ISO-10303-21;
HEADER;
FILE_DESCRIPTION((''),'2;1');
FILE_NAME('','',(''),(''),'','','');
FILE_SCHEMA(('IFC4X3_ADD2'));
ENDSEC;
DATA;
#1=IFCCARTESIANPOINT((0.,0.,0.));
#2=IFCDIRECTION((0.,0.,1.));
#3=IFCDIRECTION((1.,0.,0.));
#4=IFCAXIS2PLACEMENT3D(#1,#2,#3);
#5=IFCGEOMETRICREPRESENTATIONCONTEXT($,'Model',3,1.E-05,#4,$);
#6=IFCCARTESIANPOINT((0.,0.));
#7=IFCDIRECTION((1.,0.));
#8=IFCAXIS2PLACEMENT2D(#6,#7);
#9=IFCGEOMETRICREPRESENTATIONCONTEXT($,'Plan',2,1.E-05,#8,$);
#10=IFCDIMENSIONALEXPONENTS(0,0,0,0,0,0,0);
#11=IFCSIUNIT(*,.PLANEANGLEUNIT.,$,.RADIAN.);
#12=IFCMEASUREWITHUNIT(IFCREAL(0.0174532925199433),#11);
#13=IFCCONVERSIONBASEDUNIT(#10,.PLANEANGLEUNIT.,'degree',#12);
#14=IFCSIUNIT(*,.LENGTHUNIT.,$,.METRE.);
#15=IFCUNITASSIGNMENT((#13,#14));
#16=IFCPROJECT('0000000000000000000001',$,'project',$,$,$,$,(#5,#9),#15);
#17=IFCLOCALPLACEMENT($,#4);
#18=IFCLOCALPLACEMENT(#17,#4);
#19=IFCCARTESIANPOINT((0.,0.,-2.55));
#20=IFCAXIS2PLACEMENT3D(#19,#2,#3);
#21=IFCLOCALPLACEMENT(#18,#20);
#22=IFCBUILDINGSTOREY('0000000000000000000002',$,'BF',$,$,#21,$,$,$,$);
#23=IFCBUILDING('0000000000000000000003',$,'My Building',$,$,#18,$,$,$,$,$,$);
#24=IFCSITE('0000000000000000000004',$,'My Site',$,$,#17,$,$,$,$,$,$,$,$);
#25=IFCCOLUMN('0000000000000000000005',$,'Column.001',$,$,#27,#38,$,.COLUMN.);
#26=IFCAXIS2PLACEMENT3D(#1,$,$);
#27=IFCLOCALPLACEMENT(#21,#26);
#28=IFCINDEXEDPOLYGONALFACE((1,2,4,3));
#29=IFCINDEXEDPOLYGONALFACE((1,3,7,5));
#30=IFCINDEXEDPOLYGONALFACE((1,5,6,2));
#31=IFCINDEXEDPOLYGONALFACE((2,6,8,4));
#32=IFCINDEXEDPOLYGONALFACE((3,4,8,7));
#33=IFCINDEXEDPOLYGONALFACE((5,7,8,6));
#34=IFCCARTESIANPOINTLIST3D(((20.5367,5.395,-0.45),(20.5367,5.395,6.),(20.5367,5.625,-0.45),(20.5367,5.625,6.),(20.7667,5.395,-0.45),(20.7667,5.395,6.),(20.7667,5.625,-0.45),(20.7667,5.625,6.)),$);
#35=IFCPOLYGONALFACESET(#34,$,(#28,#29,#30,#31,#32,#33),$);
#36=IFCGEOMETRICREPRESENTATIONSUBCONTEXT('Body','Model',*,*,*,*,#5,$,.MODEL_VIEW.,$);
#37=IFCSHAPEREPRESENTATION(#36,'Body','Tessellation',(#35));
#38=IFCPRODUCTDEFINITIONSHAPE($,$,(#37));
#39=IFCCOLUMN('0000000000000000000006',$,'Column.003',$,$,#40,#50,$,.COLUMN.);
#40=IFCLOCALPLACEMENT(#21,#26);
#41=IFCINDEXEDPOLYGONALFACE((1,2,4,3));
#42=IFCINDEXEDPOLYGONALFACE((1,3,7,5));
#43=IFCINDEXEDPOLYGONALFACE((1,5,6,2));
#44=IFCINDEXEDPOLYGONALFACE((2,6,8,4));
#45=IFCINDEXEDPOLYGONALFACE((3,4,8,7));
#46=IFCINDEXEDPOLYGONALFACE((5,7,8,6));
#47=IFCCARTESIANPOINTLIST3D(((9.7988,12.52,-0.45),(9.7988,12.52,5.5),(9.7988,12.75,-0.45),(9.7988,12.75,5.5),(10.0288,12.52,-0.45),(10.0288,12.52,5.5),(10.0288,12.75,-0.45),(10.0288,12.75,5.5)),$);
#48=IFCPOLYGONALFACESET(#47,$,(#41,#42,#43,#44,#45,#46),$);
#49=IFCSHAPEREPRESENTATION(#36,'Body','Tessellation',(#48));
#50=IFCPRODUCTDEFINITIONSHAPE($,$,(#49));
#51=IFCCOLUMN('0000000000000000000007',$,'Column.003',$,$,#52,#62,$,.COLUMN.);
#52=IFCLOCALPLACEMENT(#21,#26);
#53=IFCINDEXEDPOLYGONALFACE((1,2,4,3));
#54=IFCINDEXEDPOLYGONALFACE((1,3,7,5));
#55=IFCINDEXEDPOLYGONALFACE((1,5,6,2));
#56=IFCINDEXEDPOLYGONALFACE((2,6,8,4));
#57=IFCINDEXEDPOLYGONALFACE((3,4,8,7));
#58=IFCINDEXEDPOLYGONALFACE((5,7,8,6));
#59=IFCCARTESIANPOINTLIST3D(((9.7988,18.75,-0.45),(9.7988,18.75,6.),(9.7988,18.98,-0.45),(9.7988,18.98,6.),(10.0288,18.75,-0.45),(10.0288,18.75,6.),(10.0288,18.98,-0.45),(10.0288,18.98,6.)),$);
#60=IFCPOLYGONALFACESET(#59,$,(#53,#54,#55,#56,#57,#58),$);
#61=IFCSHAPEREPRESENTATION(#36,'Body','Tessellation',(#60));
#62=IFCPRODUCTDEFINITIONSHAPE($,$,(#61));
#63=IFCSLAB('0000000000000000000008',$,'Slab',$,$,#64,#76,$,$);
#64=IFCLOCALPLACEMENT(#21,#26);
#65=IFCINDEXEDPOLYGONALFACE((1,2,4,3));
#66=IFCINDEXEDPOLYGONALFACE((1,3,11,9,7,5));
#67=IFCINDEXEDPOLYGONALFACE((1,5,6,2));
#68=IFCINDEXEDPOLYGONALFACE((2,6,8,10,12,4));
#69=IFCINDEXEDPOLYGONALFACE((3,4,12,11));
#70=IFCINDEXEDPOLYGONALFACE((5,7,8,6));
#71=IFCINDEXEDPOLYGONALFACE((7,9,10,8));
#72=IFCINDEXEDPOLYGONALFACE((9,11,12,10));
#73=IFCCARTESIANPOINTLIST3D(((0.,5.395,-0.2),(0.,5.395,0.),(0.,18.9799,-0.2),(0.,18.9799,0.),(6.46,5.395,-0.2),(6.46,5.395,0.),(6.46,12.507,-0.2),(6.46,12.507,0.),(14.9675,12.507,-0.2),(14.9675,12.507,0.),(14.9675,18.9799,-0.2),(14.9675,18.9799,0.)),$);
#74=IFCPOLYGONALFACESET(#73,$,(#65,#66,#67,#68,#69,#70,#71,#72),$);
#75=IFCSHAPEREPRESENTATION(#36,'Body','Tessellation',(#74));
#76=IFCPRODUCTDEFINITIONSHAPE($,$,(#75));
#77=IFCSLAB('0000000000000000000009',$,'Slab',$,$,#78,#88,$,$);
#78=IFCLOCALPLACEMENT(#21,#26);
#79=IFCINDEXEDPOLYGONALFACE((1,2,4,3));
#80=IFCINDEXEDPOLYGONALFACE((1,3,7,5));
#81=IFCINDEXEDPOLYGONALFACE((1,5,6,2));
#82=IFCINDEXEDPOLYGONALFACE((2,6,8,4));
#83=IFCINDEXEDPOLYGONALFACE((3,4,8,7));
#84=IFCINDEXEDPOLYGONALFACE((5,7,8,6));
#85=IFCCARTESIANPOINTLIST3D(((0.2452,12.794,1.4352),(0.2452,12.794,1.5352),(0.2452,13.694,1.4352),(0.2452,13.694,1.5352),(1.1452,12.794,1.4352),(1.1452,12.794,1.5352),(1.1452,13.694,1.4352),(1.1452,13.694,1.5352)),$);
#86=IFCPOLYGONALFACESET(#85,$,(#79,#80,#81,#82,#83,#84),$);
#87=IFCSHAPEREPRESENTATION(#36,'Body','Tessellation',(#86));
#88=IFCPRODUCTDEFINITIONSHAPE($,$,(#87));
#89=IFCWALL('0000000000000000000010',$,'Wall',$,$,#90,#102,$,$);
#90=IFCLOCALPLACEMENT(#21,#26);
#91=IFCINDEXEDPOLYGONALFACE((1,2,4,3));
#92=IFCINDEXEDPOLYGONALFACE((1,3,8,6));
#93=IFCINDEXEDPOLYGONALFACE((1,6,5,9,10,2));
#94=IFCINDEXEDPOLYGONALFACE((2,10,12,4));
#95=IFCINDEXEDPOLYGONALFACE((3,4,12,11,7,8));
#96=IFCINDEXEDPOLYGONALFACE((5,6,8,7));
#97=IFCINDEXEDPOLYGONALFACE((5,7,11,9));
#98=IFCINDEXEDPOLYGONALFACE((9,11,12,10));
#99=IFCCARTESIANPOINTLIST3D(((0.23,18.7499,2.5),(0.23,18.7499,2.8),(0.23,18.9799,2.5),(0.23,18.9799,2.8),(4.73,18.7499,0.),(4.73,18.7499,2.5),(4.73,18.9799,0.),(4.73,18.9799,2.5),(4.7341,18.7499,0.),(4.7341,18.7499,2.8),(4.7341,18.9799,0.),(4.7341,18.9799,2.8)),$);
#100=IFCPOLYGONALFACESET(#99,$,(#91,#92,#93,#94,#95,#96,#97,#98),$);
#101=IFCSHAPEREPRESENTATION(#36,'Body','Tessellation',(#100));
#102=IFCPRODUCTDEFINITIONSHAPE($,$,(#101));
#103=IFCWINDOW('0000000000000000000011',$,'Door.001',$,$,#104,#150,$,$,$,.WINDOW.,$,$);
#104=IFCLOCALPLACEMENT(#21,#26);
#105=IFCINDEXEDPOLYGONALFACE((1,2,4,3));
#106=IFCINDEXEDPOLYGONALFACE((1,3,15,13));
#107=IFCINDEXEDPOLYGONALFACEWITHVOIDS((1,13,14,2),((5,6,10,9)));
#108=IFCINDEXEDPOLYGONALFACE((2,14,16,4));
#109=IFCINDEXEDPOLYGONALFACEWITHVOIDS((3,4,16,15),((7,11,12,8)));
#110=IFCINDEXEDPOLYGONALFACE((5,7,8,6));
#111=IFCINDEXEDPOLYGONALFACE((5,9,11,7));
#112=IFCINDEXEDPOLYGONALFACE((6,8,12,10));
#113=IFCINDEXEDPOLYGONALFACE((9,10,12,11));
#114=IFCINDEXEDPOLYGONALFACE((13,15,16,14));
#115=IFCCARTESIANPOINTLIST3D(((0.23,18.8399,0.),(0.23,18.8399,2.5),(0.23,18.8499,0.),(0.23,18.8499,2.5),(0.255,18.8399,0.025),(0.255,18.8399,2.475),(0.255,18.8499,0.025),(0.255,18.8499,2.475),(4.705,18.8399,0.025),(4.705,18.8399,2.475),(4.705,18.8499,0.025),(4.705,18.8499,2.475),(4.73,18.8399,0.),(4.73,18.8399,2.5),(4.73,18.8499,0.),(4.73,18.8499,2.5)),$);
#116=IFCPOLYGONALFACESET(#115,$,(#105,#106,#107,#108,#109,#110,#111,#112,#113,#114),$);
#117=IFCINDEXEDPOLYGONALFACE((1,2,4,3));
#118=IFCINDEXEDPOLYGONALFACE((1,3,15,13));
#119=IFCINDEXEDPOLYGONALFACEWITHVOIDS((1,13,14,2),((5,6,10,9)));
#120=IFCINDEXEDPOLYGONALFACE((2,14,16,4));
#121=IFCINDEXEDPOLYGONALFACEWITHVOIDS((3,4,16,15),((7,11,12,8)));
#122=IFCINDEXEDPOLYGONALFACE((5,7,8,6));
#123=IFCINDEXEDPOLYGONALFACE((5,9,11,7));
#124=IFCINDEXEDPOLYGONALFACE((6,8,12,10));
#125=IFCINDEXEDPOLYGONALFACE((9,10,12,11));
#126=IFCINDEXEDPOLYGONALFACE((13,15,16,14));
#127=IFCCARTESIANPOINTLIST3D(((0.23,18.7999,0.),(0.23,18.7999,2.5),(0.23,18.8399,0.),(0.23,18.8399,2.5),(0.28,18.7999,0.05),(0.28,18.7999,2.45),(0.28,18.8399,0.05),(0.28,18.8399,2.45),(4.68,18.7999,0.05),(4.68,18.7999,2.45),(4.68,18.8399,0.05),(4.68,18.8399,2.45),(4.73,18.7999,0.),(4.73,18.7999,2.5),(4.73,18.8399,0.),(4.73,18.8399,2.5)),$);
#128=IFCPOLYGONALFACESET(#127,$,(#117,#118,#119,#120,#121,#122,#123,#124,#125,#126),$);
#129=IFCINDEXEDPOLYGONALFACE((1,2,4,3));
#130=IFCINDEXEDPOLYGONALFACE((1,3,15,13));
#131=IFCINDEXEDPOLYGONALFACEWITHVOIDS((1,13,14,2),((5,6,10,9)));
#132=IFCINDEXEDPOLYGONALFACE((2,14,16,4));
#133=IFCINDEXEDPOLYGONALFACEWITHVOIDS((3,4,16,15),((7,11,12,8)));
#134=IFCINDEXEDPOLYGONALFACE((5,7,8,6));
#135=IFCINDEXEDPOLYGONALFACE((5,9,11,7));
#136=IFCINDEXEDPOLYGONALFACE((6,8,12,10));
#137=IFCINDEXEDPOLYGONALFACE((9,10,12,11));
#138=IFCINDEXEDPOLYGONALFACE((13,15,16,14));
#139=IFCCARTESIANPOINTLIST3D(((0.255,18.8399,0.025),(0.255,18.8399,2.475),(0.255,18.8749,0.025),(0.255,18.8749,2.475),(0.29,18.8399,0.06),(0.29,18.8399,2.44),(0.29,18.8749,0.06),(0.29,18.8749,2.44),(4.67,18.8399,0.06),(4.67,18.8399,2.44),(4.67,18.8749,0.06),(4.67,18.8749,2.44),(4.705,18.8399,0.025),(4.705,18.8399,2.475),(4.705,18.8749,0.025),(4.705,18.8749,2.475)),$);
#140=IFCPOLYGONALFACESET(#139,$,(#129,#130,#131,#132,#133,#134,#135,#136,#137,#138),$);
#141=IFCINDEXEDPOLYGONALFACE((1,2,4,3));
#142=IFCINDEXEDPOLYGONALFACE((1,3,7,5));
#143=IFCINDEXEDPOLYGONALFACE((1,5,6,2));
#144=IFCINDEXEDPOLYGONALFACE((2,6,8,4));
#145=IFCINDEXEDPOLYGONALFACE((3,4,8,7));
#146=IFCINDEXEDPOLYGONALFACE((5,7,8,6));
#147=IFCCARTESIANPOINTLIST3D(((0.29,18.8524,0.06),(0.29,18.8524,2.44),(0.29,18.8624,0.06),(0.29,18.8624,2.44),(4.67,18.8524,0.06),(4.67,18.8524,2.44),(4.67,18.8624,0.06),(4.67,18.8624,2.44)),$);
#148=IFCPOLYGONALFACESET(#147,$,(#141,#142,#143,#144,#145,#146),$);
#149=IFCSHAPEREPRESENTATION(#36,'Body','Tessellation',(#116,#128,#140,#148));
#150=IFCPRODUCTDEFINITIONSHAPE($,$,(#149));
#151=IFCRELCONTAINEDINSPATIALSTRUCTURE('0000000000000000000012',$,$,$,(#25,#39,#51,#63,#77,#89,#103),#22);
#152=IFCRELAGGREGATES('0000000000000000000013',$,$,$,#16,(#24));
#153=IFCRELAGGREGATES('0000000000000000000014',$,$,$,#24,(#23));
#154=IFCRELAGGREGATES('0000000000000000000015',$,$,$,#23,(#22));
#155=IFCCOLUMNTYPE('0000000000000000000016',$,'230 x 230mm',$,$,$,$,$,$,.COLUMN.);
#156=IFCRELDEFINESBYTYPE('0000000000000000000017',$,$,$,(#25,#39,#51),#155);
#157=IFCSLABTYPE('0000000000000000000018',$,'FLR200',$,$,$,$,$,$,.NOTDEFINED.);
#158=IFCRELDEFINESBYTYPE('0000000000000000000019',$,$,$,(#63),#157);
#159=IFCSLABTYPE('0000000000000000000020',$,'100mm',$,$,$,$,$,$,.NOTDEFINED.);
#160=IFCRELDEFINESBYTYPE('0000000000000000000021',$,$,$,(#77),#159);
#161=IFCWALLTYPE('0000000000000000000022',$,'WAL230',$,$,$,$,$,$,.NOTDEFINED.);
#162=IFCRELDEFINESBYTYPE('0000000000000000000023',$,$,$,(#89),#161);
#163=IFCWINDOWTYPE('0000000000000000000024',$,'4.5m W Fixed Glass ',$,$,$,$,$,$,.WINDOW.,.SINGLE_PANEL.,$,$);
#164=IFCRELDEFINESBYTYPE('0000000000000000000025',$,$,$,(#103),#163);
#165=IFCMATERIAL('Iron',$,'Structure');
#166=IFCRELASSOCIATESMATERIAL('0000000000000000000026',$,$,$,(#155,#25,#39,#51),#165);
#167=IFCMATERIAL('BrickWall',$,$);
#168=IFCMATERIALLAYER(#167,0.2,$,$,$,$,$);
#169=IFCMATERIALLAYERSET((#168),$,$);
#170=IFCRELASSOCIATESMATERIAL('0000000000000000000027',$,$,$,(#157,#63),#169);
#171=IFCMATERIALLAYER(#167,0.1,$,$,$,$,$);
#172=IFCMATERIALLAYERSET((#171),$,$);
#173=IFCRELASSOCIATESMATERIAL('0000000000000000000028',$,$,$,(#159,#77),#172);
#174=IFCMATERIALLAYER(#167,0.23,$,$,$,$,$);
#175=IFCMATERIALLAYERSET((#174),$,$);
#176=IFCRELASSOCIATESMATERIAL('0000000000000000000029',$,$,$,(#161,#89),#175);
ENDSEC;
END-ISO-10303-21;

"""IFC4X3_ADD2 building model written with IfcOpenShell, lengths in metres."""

from ifc_helpers import new_model, entity, si_unit, converted_unit, frame, origin_with_axes, origin_2d_with_axis, place, context, subcontext, project, spatial, line, indexed_curve, rectangle, outline, extrude, shape, source, transform, mapped, material, layer, layer_set, layer_usage, material_profile, profile_set, profile_usage, type_object, type_shapes, element, fill, save


model = new_model("IFC4X3_ADD2")

# Units and contexts
model_context = context("Model", 3, precision=1e-05, world=origin_with_axes())
plan_context = context("Plan", 2, precision=1e-05, world=origin_2d_with_axis())
body_context_1 = subcontext(model_context, "Body", "Model", "MODEL_VIEW")
body_context_2 = subcontext(plan_context, "Body", "Plan", "PLAN_VIEW")
ifc_project = project(units=[converted_unit("PLANEANGLEUNIT", "degree", entity("IfcReal", 0.0174532925199433), si_unit("PLANEANGLEUNIT", "RADIAN"), dimensions=[0, 0, 0, 0, 0, 0, 0]), si_unit("LENGTHUNIT", "METRE")], contexts=[model_context, plan_context])

# Site, building, storey
site_placement = place(None, origin_with_axes())
site = spatial("IfcSite", under=ifc_project, at=site_placement, Name="My Site")
building_placement = place(site_placement, origin_with_axes())
building = spatial("IfcBuilding", under=site, at=building_placement, Name="My Building")
storey_placement = place(building_placement, frame((0.0, 0.0, -2.55), z_axis=(0.0, 0.0, 1.0), x_axis=(1.0, 0.0, 0.0)))
storey = spatial("IfcBuildingStorey", under=building, at=storey_placement, Name="BF")

# Columns
ifc_material_1 = material(Name="Iron", Category="Structure")
ifc_material_profile = material_profile(ifc_material_1, rectangle(XDim=0.23, YDim=0.23))
ifc_profile_set = profile_set([ifc_material_profile])
column_type = type_object("IfcColumnType", Name="230 x 230mm", PredefinedType="COLUMN", material=ifc_profile_set)
ifc_profile_usage_1 = profile_usage(ifc_profile_set)
column_1_placement = place(storey_placement, frame((20.6517, 5.51, -0.45), z_axis=(0.0, 0.0, 1.0), x_axis=(1.0, 0.0, 0.0)))
element("IfcColumn", 1, at=column_1_placement, inside=storey, type_object=column_type, material=ifc_profile_usage_1, Name="Column.001", PredefinedType="COLUMN", context=body_context_1, shape_type="SweptSolid", body=[
    extrude(rectangle(XDim=0.23, YDim=0.23), origin_with_axes(), (0.0, 0.0, 1.0), 6.45),
])
ifc_profile_usage_2 = profile_usage(ifc_profile_set)
column_2_placement = place(storey_placement, frame((9.9138, 12.635, -0.45), z_axis=(0.0, 0.0, 1.0), x_axis=(1.0, 0.0, 0.0)))
element("IfcColumn", 2, at=column_2_placement, inside=storey, type_object=column_type, material=ifc_profile_usage_2, Name="Column.003", PredefinedType="COLUMN", context=body_context_1, shape_type="SweptSolid", body=[
    extrude(rectangle(XDim=0.23, YDim=0.23), origin_with_axes(), (0.0, 0.0, 1.0), 5.95),
])
ifc_profile_usage_3 = profile_usage(ifc_profile_set)
column_3_placement = place(storey_placement, frame((9.9138, 18.865, -0.45), z_axis=(0.0, 0.0, 1.0), x_axis=(1.0, 0.0, 0.0)))
element("IfcColumn", 3, at=column_3_placement, inside=storey, type_object=column_type, material=ifc_profile_usage_3, Name="Column.003", PredefinedType="COLUMN", context=body_context_1, shape_type="SweptSolid", body=[
    extrude(rectangle(XDim=0.23, YDim=0.23), origin_with_axes(), (0.0, 0.0, 1.0), 6.45),
])

# Slabs
ifc_material_2 = material(Name="BrickWall")
ifc_layer_1 = layer(ifc_material_2, 0.2)
ifc_layer_set_1 = layer_set([ifc_layer_1])
ifc_layer_usage_1 = layer_usage(ifc_layer_set_1, "AXIS3", "POSITIVE", 0.0)
slab_type_1 = type_object("IfcSlabType", Name="FLR200", PredefinedType="NOTDEFINED", material=ifc_layer_set_1)
slab_1_placement = place(storey_placement, frame((0.0, 5.395, -0.2), z_axis=(0.0, 0.0, 1.0), x_axis=(1.0, 0.0, 0.0)))
element("IfcSlab", 4, at=slab_1_placement, inside=storey, type_object=slab_type_1, material=ifc_layer_usage_1, Name="Slab", context=body_context_1, shape_type="SweptSolid", body=[
    extrude(outline(indexed_curve([(6.46, 0.0), (6.46, 7.112), (14.9675, 7.112), (14.9675, 13.5849), (0.0, 13.5849), (0.0, 0.0)], segments=[line(1, 6), line(6, 5), line(5, 4), line(4, 3), line(3, 2), line(2, 1)], self_intersect=False)), None, (0.0, 0.0, 1.0), 0.2),
])
ifc_layer_2 = layer(ifc_material_2, 0.1)
ifc_layer_set_2 = layer_set([ifc_layer_2])
ifc_layer_usage_2 = layer_usage(ifc_layer_set_2, "AXIS3", "POSITIVE", 0.0)
slab_type_2 = type_object("IfcSlabType", Name="100mm", PredefinedType="NOTDEFINED", material=ifc_layer_set_2)
slab_2_placement = place(storey_placement, frame((1.1452, 13.794, 1.4352), z_axis=(0.0, 0.0, 1.0), x_axis=(-1.0, 0.0, 0.0)))
element("IfcSlab", 5, at=slab_2_placement, inside=storey, type_object=slab_type_2, material=ifc_layer_usage_2, Name="Slab", context=body_context_1, shape_type="SweptSolid", body=[
    extrude(outline(indexed_curve([(0.0, 1.0), (0.9, 1.0), (0.9, 0.1), (0.0, 0.1)], segments=[line(4, 1), line(1, 2), line(2, 3), line(3, 4)], self_intersect=False)), None, (0.0, 0.0, 1.0), 0.1),
])

# Wall, opening, window
ifc_layer_3 = layer(ifc_material_2, 0.23)
ifc_layer_set_3 = layer_set([ifc_layer_3])
ifc_layer_usage_3 = layer_usage(ifc_layer_set_3, "AXIS2", "POSITIVE", 0.0)
wall_type = type_object("IfcWallType", Name="WAL230", PredefinedType="NOTDEFINED", material=ifc_layer_set_3)
wall_1_placement = place(storey_placement, frame((0.23, 18.7499, 0.0), z_axis=(0.0, 0.0, 1.0), x_axis=(1.0, 0.0, 0.0)))
wall_1 = element("IfcWall", 6, at=wall_1_placement, inside=storey, type_object=wall_type, material=ifc_layer_usage_3, Name="Wall", context=body_context_1, shape_type="SweptSolid", body=[
    extrude(outline(indexed_curve([(0.0, 0.0), (0.0, 0.23), (4.5041, 0.23), (4.5041, 0.0), (0.0, 0.0)], self_intersect=False)), origin_with_axes(), (0.0, 0.0, 1.0), 2.8),
])
shared_shape_1 = source(origin_with_axes(), body_context_1, "Body", "SweptSolid", [
    extrude(outline(indexed_curve([(0.0, 0.0), (4.5, 0.0), (4.5, 2.5), (0.0, 2.5)], segments=[line(1, 2, 3, 4, 1)])), frame((0.0, -0.6, 0.0), z_axis=(0.0, -1.0, 0.0), x_axis=(1.0, 0.0, 0.0)), (0.0, 0.0, -1.0), 1.2),
])
opening_1_placement = place(wall_1_placement, frame((0.0, 0.0, 0.0), z_axis=(0.0, 0.0, 1.0), x_axis=(1.0, 0.0, 0.0)))
opening_1 = element("IfcOpeningElement", 7, at=opening_1_placement, cuts=wall_1, PredefinedType="OPENING", context=body_context_1, shape_type="MappedRepresentation", body=[
    mapped(shared_shape_1, transform((0.0, 0.0, 0.0), x_axis=(1.0, 0.0, 0.0), y_axis=(0.0, 1.0, 0.0), z_axis=(0.0, 0.0, 1.0), scale=1.0)),
])
window_type_1 = type_object("IfcWindowType", Name="4.5m W Fixed Glass ", PartitioningType="SINGLE_PANEL", PredefinedType="WINDOW")
shared_shape_2 = source(origin_with_axes(), body_context_1, "Body", "SweptSolid", [
    extrude(outline(indexed_curve([(0.0, 0.0), (4.5, 0.0), (4.5, 2.5), (0.0, 2.5)], segments=[line(1, 2, 3, 4, 1)]), holes=[indexed_curve([(0.025, 0.025), (4.475, 0.025), (4.475, 2.475), (0.025, 2.475)], segments=[line(1, 2, 3, 4, 1)])]), frame((0.0, 0.09, 0.0), z_axis=(0.0, -1.0, 0.0), x_axis=(1.0, 0.0, 0.0)), (0.0, 0.0, -1.0), 0.01),
    extrude(outline(indexed_curve([(0.0, 0.0), (4.5, 0.0), (4.5, 2.5), (0.0, 2.5)], segments=[line(1, 2, 3, 4, 1)]), holes=[indexed_curve([(0.05, 0.05), (4.45, 0.05), (4.45, 2.45), (0.05, 2.45)], segments=[line(1, 2, 3, 4, 1)])]), frame((0.0, 0.05, 0.0), z_axis=(0.0, -1.0, 0.0), x_axis=(1.0, 0.0, 0.0)), (0.0, 0.0, -1.0), 0.04),
    extrude(outline(indexed_curve([(0.0, 0.0), (4.45, 0.0), (4.45, 2.45), (0.0, 2.45)], segments=[line(1, 2, 3, 4, 1)]), holes=[indexed_curve([(0.035, 0.035), (4.415, 0.035), (4.415, 2.415), (0.035, 2.415)], segments=[line(1, 2, 3, 4, 1)])]), frame((0.025, 0.09, 0.025), z_axis=(0.0, -1.0, 0.0), x_axis=(1.0, 0.0, 0.0)), (0.0, 0.0, -1.0), 0.035),
    extrude(outline(indexed_curve([(0.035, 0.035), (4.415, 0.035), (4.415, 2.415), (0.035, 2.415)], segments=[line(1, 2, 3, 4, 1)])), frame((0.025, 0.1025, 0.025), z_axis=(0.0, -1.0, 0.0), x_axis=(1.0, 0.0, 0.0)), (0.0, 0.0, -1.0), 0.01),
])
shared_shape_3 = source(origin_with_axes(), body_context_2, "Body", "Curve2D", [
    entity("IfcIndexedPolyCurve", entity("IfcCartesianPointList2D", [[0.05, 0.05], [4.45, 0.05]])),
    entity("IfcIndexedPolyCurve", entity("IfcCartesianPointList2D", [[0.0, 0.1], [0.025, 0.1], [0.025, 0.09], [0.05, 0.09], [0.05, 0.05], [0.0, 0.05]]), [entity("IfcLineIndex", [1, 2, 3, 4, 5, 6, 1])]),
    entity("IfcIndexedPolyCurve", entity("IfcCartesianPointList2D", [[4.5, 0.1], [4.475, 0.1], [4.475, 0.09], [4.45, 0.09], [4.45, 0.05], [4.5, 0.05]]), [entity("IfcLineIndex", [1, 2, 3, 4, 5, 6, 1])]),
    entity("IfcIndexedPolyCurve", entity("IfcCartesianPointList2D", [[0.025, 0.09], [0.06, 0.09], [0.06, 0.125], [0.025, 0.125]]), [entity("IfcLineIndex", [1, 2, 3, 4, 1])]),
    entity("IfcIndexedPolyCurve", entity("IfcCartesianPointList2D", [[4.475, 0.09], [4.44, 0.09], [4.44, 0.125], [4.475, 0.125]]), [entity("IfcLineIndex", [1, 2, 3, 4, 1])]),
    entity("IfcIndexedPolyCurve", entity("IfcCartesianPointList2D", [[0.06, 0.09], [4.44, 0.09]])),
    entity("IfcIndexedPolyCurve", entity("IfcCartesianPointList2D", [[0.06, 0.125], [4.44, 0.125]])),
    entity("IfcIndexedPolyCurve", entity("IfcCartesianPointList2D", [[0.06, 0.1075], [4.44, 0.1075]])),
])
type_shapes(window_type_1, [shared_shape_2, shared_shape_3])
window_1_placement = place(opening_1_placement, origin_with_axes())
window_1 = element("IfcWindow", 8, at=window_1_placement, inside=storey, type_object=window_type_1, Name="Door.001", PredefinedType="WINDOW", shapes=[
    shape(body_context_1, "Body", "MappedRepresentation", [mapped(shared_shape_2, transform((0.0, 0.0, 0.0), x_axis=(1.0, 0.0, 0.0), y_axis=(0.0, 1.0, 0.0), z_axis=(0.0, 0.0, 1.0), scale=1.0))]),
    shape(body_context_2, "Body", "MappedRepresentation", [mapped(shared_shape_3, transform((0.0, 0.0, 0.0), x_axis=(1.0, 0.0, 0.0), y_axis=(0.0, 1.0, 0.0), z_axis=(0.0, 0.0, 1.0), scale=1.0))]),
])
fill(opening_1, window_1)

save(model, "model.ifc")
